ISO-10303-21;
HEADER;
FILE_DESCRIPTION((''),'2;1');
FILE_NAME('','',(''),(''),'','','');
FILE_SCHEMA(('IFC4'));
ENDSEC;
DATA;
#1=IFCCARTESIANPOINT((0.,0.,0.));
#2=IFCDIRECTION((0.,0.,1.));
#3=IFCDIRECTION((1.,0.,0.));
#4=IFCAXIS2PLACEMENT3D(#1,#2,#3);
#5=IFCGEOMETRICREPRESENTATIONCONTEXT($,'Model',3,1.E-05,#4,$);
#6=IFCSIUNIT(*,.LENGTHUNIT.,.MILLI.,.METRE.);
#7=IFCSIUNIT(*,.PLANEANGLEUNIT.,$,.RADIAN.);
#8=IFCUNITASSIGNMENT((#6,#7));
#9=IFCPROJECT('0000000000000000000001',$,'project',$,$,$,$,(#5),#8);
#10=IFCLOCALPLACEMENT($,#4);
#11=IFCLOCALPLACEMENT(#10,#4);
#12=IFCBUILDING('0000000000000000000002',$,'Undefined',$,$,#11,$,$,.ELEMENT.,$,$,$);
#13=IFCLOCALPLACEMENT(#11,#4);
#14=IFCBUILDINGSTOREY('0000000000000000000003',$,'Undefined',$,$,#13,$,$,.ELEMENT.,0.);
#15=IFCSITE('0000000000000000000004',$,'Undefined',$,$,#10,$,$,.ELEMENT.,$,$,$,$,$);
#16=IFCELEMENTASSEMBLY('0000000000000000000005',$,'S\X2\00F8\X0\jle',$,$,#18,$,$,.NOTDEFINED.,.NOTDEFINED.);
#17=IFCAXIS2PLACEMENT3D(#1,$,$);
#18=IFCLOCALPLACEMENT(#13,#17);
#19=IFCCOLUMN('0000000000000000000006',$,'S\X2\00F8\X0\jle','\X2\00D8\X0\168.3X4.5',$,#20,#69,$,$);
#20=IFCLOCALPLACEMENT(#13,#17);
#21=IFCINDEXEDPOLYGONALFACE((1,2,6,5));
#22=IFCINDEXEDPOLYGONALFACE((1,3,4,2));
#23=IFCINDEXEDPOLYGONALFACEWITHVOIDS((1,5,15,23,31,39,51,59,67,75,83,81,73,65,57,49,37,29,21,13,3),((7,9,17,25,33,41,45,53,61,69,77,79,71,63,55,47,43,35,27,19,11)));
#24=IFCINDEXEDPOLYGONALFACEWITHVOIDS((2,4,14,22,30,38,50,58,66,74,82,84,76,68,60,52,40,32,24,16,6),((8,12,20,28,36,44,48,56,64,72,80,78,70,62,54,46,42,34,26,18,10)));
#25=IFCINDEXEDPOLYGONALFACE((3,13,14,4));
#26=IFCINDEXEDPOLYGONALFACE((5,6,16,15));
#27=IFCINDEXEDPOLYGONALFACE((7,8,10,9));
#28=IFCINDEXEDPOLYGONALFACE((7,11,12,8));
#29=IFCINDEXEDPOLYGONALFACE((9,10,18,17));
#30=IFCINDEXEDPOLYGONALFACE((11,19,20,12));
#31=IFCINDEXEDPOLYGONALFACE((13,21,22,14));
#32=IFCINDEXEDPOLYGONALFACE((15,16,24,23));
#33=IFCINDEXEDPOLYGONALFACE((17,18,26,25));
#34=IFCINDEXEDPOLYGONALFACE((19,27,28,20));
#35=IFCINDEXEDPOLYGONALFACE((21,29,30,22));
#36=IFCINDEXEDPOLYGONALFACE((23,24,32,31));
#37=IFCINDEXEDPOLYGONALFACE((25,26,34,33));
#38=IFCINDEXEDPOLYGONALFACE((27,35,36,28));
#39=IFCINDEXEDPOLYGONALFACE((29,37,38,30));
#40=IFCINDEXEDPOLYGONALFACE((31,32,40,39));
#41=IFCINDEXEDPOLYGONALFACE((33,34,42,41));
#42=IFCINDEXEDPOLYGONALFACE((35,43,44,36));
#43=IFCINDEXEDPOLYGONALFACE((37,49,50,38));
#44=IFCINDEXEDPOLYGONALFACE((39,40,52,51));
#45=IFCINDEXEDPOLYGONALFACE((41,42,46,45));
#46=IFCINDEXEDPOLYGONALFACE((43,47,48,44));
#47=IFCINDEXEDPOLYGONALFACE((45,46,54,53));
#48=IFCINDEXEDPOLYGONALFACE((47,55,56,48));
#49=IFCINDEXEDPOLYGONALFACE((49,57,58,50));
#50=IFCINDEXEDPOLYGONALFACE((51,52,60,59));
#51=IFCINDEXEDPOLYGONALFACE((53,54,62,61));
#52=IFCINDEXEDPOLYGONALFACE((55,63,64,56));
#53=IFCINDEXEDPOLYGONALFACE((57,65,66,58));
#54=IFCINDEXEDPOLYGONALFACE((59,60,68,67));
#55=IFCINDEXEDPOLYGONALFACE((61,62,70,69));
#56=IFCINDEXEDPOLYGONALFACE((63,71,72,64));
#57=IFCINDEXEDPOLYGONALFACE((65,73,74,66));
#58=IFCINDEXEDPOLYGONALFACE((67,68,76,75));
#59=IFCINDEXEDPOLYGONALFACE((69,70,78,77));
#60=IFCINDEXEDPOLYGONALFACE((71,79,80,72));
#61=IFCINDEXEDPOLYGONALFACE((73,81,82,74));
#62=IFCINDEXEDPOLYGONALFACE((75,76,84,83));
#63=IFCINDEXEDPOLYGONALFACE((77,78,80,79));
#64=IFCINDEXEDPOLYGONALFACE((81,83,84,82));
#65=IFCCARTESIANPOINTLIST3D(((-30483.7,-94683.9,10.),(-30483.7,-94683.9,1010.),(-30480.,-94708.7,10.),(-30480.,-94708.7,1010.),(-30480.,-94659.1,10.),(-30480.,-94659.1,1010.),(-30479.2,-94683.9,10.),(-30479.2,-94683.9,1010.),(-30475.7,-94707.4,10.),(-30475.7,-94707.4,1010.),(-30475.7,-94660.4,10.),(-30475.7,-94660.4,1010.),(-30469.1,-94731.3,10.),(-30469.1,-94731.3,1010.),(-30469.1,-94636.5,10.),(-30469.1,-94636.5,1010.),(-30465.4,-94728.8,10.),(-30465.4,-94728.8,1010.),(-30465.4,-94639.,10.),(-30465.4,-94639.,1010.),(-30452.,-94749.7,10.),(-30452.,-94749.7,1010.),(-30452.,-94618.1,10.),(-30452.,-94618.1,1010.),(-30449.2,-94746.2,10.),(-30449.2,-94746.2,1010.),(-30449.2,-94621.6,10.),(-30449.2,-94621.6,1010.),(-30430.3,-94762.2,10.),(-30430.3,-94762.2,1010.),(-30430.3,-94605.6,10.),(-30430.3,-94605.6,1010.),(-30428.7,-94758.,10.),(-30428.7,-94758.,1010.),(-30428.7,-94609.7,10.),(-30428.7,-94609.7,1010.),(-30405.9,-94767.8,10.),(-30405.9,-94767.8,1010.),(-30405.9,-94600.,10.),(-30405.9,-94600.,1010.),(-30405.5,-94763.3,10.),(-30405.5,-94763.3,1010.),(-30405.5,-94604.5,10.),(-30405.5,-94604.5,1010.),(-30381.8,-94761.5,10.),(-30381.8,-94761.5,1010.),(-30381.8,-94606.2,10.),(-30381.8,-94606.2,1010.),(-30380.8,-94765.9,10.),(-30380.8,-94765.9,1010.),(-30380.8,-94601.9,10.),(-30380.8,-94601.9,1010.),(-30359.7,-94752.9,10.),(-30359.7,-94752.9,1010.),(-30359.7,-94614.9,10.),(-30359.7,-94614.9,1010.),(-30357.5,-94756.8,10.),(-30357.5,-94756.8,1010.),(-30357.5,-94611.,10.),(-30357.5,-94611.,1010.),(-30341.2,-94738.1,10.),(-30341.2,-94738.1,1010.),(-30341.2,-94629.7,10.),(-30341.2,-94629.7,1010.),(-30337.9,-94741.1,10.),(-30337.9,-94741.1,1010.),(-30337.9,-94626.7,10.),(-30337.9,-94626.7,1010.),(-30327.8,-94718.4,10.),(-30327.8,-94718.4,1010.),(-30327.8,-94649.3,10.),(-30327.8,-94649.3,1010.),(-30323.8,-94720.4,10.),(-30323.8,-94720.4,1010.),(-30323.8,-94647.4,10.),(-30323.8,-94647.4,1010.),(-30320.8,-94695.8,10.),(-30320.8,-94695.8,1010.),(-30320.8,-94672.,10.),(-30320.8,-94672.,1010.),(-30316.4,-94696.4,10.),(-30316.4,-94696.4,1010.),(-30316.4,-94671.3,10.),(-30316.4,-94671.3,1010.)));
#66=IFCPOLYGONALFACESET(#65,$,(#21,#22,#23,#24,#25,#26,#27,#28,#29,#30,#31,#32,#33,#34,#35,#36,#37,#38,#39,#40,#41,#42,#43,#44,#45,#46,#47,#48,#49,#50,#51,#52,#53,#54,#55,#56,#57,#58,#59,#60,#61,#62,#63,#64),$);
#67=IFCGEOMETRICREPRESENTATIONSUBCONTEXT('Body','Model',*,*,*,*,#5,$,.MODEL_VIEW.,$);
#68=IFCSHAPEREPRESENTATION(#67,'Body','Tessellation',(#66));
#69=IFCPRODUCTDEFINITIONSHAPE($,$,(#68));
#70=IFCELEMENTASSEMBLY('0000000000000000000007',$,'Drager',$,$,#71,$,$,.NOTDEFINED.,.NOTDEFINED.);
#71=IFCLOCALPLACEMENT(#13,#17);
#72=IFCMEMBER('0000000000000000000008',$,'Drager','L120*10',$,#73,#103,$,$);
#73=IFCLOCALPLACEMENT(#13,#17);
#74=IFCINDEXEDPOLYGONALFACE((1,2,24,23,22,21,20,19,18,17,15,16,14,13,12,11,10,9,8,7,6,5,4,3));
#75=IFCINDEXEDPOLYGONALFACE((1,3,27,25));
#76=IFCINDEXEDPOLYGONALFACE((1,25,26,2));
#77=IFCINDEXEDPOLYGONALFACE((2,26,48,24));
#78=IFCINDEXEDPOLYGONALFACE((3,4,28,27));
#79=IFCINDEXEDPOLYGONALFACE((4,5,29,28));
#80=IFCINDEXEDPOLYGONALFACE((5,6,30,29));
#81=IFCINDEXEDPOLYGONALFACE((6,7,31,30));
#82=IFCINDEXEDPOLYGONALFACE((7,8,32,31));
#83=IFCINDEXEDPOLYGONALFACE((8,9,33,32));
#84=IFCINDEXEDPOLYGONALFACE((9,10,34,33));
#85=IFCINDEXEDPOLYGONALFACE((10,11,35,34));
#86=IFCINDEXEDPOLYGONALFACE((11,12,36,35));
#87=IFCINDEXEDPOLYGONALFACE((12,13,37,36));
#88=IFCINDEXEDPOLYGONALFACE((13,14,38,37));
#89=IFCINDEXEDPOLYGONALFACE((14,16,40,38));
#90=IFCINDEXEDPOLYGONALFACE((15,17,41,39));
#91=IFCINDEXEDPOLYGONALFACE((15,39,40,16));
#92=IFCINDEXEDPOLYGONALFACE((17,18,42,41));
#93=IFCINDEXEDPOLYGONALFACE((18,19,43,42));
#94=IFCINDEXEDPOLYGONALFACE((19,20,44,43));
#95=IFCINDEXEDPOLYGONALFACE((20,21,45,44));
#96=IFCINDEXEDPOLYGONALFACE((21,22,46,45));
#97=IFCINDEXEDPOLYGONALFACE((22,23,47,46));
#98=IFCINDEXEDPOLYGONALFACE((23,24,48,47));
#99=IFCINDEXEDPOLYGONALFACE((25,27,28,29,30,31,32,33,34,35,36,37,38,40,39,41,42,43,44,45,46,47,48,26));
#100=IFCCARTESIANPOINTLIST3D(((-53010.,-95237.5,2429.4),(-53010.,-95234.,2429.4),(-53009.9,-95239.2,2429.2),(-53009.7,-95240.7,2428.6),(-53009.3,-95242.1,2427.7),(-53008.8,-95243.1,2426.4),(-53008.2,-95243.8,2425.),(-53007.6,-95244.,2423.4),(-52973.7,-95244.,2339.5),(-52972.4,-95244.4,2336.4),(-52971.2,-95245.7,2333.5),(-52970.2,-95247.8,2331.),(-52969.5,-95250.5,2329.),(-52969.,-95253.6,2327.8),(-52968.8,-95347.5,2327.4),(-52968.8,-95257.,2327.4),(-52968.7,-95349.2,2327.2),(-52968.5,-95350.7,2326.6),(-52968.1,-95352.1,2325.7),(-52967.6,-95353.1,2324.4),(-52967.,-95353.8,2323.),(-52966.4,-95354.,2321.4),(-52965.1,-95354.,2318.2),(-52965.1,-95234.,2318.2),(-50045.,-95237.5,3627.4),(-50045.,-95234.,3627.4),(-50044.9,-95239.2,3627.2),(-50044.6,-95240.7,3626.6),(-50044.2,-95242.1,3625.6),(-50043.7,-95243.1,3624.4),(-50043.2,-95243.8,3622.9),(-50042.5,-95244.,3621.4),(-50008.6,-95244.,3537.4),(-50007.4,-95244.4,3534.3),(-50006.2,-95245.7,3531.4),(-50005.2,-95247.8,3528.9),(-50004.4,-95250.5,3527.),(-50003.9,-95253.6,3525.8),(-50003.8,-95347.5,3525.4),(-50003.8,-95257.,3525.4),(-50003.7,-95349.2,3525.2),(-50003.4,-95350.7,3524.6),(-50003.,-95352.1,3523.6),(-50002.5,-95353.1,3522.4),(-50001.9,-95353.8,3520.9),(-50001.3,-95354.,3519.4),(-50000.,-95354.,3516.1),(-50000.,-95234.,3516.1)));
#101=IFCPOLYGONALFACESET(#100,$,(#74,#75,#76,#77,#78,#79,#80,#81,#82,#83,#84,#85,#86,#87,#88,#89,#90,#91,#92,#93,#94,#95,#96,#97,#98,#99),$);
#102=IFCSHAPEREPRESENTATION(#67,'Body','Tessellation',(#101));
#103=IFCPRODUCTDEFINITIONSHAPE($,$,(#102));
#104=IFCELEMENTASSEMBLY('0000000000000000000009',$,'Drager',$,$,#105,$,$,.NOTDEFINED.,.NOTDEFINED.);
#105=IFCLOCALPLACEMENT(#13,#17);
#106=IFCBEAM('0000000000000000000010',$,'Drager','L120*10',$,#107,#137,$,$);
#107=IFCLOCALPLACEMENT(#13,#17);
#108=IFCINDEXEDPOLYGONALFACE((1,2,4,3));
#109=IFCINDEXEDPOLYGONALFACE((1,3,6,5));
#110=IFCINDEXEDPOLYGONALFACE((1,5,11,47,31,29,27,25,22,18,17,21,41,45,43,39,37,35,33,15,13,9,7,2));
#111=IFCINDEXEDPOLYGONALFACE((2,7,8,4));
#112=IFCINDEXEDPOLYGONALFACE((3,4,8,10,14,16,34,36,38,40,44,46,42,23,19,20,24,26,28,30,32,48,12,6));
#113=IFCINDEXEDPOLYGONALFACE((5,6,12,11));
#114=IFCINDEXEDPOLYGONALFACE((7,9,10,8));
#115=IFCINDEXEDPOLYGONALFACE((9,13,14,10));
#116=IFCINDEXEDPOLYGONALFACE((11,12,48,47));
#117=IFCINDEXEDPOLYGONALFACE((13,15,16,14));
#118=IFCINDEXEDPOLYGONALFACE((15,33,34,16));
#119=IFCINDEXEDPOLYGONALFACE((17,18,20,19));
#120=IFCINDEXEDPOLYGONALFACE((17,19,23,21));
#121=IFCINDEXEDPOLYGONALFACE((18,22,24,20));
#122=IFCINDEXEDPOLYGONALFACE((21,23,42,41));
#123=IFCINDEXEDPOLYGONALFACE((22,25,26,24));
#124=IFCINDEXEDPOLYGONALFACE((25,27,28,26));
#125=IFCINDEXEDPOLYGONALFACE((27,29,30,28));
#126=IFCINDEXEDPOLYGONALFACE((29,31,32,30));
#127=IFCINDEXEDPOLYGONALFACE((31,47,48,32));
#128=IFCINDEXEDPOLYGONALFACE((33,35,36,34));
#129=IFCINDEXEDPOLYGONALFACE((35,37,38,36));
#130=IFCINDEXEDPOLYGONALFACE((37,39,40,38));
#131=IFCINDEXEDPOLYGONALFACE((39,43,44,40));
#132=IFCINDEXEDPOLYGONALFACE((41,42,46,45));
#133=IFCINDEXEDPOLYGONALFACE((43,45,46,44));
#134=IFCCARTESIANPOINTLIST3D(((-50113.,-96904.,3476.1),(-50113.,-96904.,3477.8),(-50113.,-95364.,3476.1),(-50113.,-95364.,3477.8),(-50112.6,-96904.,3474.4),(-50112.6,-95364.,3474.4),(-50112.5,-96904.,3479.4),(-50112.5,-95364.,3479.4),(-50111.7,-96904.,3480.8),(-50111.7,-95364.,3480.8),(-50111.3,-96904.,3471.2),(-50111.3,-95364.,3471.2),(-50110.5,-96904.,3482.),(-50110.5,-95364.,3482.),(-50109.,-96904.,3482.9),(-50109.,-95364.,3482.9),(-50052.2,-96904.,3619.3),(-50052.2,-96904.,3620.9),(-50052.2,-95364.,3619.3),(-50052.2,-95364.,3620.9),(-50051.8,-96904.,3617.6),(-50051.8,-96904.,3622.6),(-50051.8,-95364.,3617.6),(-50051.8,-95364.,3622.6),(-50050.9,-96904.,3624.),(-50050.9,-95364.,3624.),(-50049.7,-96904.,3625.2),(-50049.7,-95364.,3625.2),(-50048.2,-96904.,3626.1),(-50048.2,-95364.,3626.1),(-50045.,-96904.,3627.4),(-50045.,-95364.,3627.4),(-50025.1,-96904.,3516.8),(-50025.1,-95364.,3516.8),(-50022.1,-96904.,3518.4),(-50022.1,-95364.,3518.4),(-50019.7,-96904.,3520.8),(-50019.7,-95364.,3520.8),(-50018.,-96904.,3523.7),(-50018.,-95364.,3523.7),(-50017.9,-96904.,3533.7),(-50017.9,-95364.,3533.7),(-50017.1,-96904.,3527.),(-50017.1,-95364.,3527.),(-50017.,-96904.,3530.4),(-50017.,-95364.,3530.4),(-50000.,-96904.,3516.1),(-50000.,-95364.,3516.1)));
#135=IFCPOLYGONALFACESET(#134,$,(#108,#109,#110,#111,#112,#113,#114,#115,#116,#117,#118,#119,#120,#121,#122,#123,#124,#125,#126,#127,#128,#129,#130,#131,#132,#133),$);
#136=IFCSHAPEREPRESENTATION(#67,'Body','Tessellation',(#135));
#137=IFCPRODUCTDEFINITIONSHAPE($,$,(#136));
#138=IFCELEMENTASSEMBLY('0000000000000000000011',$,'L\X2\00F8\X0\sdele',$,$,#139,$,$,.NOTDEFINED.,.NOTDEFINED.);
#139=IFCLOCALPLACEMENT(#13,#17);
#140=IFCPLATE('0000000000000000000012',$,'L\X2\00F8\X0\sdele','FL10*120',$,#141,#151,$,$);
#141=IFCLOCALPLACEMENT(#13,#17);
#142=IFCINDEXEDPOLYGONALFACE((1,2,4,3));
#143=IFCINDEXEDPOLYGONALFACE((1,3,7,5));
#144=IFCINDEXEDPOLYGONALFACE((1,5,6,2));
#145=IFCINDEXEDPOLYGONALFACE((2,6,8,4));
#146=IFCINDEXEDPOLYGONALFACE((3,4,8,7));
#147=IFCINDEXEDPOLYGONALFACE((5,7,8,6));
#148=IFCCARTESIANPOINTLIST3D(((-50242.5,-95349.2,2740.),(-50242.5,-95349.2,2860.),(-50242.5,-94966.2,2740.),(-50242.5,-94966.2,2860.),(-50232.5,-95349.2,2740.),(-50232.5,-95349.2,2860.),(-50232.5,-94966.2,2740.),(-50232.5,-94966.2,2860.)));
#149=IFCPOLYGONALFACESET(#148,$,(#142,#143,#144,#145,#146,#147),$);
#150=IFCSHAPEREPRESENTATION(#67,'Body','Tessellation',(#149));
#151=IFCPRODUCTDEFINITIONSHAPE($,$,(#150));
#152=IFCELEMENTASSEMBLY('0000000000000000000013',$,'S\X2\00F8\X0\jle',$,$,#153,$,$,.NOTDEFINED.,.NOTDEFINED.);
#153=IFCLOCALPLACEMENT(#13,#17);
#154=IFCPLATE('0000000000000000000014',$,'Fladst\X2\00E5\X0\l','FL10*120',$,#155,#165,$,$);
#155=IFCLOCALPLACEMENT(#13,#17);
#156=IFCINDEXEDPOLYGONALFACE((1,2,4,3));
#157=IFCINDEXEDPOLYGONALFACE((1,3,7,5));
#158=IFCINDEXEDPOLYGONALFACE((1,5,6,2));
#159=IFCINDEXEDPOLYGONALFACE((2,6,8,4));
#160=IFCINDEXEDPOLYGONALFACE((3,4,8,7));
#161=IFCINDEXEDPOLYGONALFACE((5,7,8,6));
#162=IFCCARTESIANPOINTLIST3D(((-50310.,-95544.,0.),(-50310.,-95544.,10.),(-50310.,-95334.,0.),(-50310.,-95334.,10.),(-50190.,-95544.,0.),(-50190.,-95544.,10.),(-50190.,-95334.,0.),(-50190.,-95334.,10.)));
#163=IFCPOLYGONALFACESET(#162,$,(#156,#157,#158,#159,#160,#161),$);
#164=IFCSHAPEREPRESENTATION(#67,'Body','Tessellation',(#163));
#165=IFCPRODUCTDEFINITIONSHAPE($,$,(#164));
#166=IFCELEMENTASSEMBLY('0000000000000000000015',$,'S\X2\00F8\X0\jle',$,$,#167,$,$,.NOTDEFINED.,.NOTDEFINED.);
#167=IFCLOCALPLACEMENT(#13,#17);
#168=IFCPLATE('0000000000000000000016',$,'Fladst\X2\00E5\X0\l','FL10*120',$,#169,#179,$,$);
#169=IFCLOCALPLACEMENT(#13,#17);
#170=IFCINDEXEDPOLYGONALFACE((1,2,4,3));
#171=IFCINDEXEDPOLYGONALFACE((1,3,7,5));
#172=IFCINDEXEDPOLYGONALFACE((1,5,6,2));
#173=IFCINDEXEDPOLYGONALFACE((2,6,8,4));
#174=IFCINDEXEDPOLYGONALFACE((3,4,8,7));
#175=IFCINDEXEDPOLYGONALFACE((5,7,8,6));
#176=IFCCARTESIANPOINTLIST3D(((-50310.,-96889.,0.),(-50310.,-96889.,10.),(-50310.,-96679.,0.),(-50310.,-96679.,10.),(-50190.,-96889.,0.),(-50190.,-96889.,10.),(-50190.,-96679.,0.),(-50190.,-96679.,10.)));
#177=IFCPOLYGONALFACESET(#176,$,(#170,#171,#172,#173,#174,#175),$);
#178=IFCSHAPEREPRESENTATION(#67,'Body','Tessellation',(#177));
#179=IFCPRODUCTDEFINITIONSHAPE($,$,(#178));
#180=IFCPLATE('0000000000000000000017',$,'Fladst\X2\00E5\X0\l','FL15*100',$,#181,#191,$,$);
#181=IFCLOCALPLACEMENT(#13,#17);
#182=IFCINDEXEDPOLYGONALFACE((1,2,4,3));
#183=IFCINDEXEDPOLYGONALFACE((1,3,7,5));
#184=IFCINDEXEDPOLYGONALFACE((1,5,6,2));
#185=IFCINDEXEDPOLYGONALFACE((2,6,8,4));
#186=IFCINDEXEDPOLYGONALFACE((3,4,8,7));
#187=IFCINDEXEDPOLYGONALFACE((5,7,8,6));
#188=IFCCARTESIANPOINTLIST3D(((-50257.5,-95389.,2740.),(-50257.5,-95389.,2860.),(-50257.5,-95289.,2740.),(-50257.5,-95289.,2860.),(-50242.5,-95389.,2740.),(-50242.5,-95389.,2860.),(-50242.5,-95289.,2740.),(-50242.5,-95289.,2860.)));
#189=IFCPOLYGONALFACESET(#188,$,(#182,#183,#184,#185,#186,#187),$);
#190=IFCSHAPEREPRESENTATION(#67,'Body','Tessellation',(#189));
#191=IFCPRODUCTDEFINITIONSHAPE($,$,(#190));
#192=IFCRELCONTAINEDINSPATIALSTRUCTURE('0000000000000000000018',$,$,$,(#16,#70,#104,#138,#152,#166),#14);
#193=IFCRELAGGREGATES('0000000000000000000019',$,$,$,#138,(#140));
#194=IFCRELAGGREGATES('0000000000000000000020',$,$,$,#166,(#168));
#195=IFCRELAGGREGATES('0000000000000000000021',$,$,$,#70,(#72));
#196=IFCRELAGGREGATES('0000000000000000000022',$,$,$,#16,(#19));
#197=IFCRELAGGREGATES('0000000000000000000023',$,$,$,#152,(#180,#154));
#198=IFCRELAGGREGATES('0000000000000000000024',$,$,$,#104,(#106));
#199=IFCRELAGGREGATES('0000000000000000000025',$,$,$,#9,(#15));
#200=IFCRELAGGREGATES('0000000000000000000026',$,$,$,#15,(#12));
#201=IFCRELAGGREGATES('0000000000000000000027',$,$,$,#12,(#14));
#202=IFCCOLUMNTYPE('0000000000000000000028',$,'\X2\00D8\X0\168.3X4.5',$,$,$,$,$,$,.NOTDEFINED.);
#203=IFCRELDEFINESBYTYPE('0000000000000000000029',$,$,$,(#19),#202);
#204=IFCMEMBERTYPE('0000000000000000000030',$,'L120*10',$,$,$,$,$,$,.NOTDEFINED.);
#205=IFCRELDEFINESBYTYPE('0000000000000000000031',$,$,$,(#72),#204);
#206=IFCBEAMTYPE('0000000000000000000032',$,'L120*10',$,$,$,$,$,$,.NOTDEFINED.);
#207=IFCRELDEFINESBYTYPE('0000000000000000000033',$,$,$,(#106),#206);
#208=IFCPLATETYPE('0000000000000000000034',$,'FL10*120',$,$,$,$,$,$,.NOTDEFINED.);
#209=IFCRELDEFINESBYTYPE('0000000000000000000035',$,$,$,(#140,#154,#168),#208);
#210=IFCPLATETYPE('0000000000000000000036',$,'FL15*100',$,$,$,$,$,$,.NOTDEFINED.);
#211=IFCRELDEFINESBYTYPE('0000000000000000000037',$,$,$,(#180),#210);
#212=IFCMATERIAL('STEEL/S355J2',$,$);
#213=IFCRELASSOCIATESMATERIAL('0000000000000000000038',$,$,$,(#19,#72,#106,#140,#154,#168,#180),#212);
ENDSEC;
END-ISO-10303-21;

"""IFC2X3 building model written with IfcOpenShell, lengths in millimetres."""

from ifc_helpers import new_model, si_unit, frame, origin_with_axes, origin_2d_with_axis, place, context, subcontext, project, spatial, polyline, hollow_circle, l_section, outline, extrude, clip, halfspace, material, type_object, element, aggregate, save


model = new_model("IFC2X3")

# Units and contexts
model_context = context("Model", 3, precision=1e-05, world=origin_with_axes())
body_context = subcontext(model_context, "Body", "Model", "MODEL_VIEW")
ifc_project = project(units=[si_unit("LENGTHUNIT", "METRE", prefix="MILLI"), si_unit("PLANEANGLEUNIT", "RADIAN")], contexts=[model_context])

# Site, building, storey
site_placement = place(None, origin_with_axes())
site = spatial("IfcSite", under=ifc_project, at=site_placement, Name="Undefined", CompositionType="ELEMENT")
building_placement = place(site_placement, origin_with_axes())
building = spatial("IfcBuilding", under=site, at=building_placement, Name="Undefined", CompositionType="ELEMENT")
storey_placement = place(building_placement, origin_with_axes())
storey = spatial("IfcBuildingStorey", under=building, at=storey_placement, Name="Undefined", CompositionType="ELEMENT", Elevation=0.0)

# Element assembly, column
ifc_material_1 = material(Name="STEEL/S355J2")
column_type = type_object("IfcColumnType", Name="Ø168.3X4.5", PredefinedType="NOTDEFINED")
assembly_1_placement = place(storey_placement, origin_with_axes())
assembly_1 = element("IfcElementAssembly", 1, at=assembly_1_placement, inside=storey, Name="Søjle", AssemblyPlace="NOTDEFINED", PredefinedType="NOTDEFINED")
column_1_placement = place(assembly_1_placement, frame((-30399.6, -94683.9, 0.0), z_axis=(0.0, 0.0, 1.0), x_axis=(0.0, 1.0, 0.0)))
column_1 = element("IfcColumn", 2, at=column_1_placement, type_object=column_type, material=ifc_material_1, Name="Søjle", Description="Ø168.3X4.5", context=body_context, shape_type="Clipping", body=[
    clip(clip(extrude(hollow_circle(Radius=84.2, WallThickness=4.5, at=origin_2d_with_axis()), frame((0.0, 0.0, 1010.0), z_axis=(0.0, 0.0, -1.0), x_axis=(0.0, 1.0, 0.0)), (0.0, 0.0, 1.0), 1010.0), halfspace(frame((-84.1, 0.0, 1010.0), z_axis=(0.0, 0.0, -1.0), x_axis=(0.0, -1.0, 0.0)), True)), halfspace(frame((-84.1, 0.0, 10.0), z_axis=(0.0, 0.0, 1.0), x_axis=(0.0, 1.0, 0.0)), True)),
])

# Element assembly, member
assembly_2_placement = place(storey_placement, origin_with_axes())
assembly_2 = element("IfcElementAssembly", 3, at=assembly_2_placement, inside=storey, Name="Drager", AssemblyPlace="NOTDEFINED", PredefinedType="NOTDEFINED")
member_type = type_object("IfcMemberType", Name="L120*10", PredefinedType="NOTDEFINED")
member_placement = place(assembly_2_placement, frame((-50022.5, -95294.0, 3571.7), z_axis=(0.0, -1.0, 0.0), x_axis=(-0.927184, 0.0, -0.374606)))
member = element("IfcMember", 4, at=member_placement, type_object=member_type, material=ifc_material_1, Name="Drager", Description="L120*10", context=body_context, shape_type="Clipping", body=[
    clip(clip(extrude(l_section(Depth=120.0, Width=120.0, Thickness=10.0, FilletRadius=13.0, EdgeRadius=6.5, at=origin_2d_with_axis()), frame((3282.1, 0.0, 0.0), z_axis=(-1.0, 0.0, 0.0), x_axis=(0.0, -1.0, 0.0)), (0.0, 0.0, 1.0), 3366.3), halfspace(frame((3197.9, 0.0, -60.0), z_axis=(-1.0, 0.0, 0.0), x_axis=(0.0, 1.0, 0.0)), True)), halfspace(frame((0.0, 0.0, -60.0), z_axis=(1.0, 0.0, 0.0), x_axis=(0.0, -1.0, 0.0)), True)),
])

# Element assembly, beam
assembly_3_placement = place(storey_placement, origin_with_axes())
assembly_3 = element("IfcElementAssembly", 5, at=assembly_3_placement, inside=storey, Name="Drager", AssemblyPlace="NOTDEFINED", PredefinedType="NOTDEFINED")
beam_type = type_object("IfcBeamType", Name="L120*10", PredefinedType="NOTDEFINED")
beam_placement = place(assembly_3_placement, frame((-50078.1, -95364.0, 3549.3), z_axis=(-0.374607, 0.0, 0.927184), x_axis=(0.0, -1.0, 0.0)))
beam = element("IfcBeam", 6, at=beam_placement, type_object=beam_type, material=ifc_material_1, Name="Drager", Description="L120*10", context=body_context, shape_type="SweptSolid", body=[
    extrude(l_section(Depth=120.0, Width=120.0, Thickness=10.0, FilletRadius=13.0, EdgeRadius=6.5, at=origin_2d_with_axis()), frame((1540.0, 0.0, 0.0), z_axis=(-1.0, 0.0, 0.0), x_axis=(0.0, -1.0, 0.0)), (0.0, 0.0, 1.0), 1540.0),
])

# Element assemblies, plates
assembly_4_placement = place(storey_placement, origin_with_axes())
assembly_4 = element("IfcElementAssembly", 7, at=assembly_4_placement, inside=storey, Name="Løsdele", AssemblyPlace="NOTDEFINED", PredefinedType="NOTDEFINED")
plate_type_1 = type_object("IfcPlateType", Name="FL10*120", PredefinedType="NOTDEFINED")
plate_1_placement = place(assembly_4_placement, frame((-50237.5, -94966.2, 2740.0), z_axis=(-1.0, 0.0, 0.0), x_axis=(0.0, -1.0, 0.0)))
plate_1 = element("IfcPlate", 8, at=plate_1_placement, type_object=plate_type_1, material=ifc_material_1, Name="Løsdele", Description="FL10*120", context=body_context, shape_type="SweptSolid", body=[
    extrude(outline(polyline([(0.0, 0.0), (383.0, 0.0), (383.0, 120.0), (0.0, 120.0), (0.0, 0.0)])), frame((0.0, 0.0, -5.0), z_axis=(0.0, 0.0, 1.0), x_axis=(1.0, 0.0, 0.0)), (0.0, 0.0, 1.0), 10.0),
])
aggregate(assembly_4, [plate_1])
assembly_5_placement = place(storey_placement, origin_with_axes())
assembly_5 = element("IfcElementAssembly", 9, at=assembly_5_placement, inside=storey, Name="Søjle", AssemblyPlace="NOTDEFINED", PredefinedType="NOTDEFINED")
plate_2_placement = place(assembly_5_placement, frame((-50190.0, -95439.0, 5.0), z_axis=(0.0, 0.0, 1.0), x_axis=(-1.0, 0.0, 0.0)))
plate_2 = element("IfcPlate", 10, at=plate_2_placement, type_object=plate_type_1, material=ifc_material_1, Name="Fladstål", Description="FL10*120", context=body_context, shape_type="SweptSolid", body=[
    extrude(outline(polyline([(0.0, -105.0), (0.0, 105.0), (120.0, 105.0), (120.0, -105.0), (0.0, -105.0)])), frame((0.0, 0.0, -5.0), z_axis=(0.0, 0.0, 1.0), x_axis=(1.0, 0.0, 0.0)), (0.0, 0.0, 1.0), 10.0),
])
assembly_6_placement = place(storey_placement, origin_with_axes())
assembly_6 = element("IfcElementAssembly", 11, at=assembly_6_placement, inside=storey, Name="Søjle", AssemblyPlace="NOTDEFINED", PredefinedType="NOTDEFINED")
plate_3_placement = place(assembly_6_placement, frame((-50190.0, -96784.0, 5.0), z_axis=(0.0, 0.0, 1.0), x_axis=(-1.0, 0.0, 0.0)))
plate_3 = element("IfcPlate", 12, at=plate_3_placement, type_object=plate_type_1, material=ifc_material_1, Name="Fladstål", Description="FL10*120", context=body_context, shape_type="SweptSolid", body=[
    extrude(outline(polyline([(0.0, -105.0), (0.0, 105.0), (120.0, 105.0), (120.0, -105.0), (0.0, -105.0)])), frame((0.0, 0.0, -5.0), z_axis=(0.0, 0.0, 1.0), x_axis=(1.0, 0.0, 0.0)), (0.0, 0.0, 1.0), 10.0),
])
aggregate(assembly_6, [plate_3])

# Plate
plate_type_2 = type_object("IfcPlateType", Name="FL15*100", PredefinedType="NOTDEFINED")
plate_4_placement = place(assembly_5_placement, frame((-50250.0, -95289.0, 2740.0), z_axis=(-1.0, 0.0, 0.0), x_axis=(0.0, -1.0, 0.0)))
plate_4 = element("IfcPlate", 13, at=plate_4_placement, type_object=plate_type_2, material=ifc_material_1, Name="Fladstål", Description="FL15*100", context=body_context, shape_type="SweptSolid", body=[
    extrude(outline(polyline([(0.0, 0.0), (100.0, 0.0), (100.0, 120.0), (0.0, 120.0), (0.0, 0.0)])), frame((0.0, 0.0, -7.5), z_axis=(0.0, 0.0, 1.0), x_axis=(1.0, 0.0, 0.0)), (0.0, 0.0, 1.0), 15.0),
])
aggregate(assembly_2, [member])

aggregate(assembly_1, [column_1])

aggregate(assembly_5, [plate_4, plate_2])
aggregate(assembly_3, [beam])

save(model, "model.ifc")
